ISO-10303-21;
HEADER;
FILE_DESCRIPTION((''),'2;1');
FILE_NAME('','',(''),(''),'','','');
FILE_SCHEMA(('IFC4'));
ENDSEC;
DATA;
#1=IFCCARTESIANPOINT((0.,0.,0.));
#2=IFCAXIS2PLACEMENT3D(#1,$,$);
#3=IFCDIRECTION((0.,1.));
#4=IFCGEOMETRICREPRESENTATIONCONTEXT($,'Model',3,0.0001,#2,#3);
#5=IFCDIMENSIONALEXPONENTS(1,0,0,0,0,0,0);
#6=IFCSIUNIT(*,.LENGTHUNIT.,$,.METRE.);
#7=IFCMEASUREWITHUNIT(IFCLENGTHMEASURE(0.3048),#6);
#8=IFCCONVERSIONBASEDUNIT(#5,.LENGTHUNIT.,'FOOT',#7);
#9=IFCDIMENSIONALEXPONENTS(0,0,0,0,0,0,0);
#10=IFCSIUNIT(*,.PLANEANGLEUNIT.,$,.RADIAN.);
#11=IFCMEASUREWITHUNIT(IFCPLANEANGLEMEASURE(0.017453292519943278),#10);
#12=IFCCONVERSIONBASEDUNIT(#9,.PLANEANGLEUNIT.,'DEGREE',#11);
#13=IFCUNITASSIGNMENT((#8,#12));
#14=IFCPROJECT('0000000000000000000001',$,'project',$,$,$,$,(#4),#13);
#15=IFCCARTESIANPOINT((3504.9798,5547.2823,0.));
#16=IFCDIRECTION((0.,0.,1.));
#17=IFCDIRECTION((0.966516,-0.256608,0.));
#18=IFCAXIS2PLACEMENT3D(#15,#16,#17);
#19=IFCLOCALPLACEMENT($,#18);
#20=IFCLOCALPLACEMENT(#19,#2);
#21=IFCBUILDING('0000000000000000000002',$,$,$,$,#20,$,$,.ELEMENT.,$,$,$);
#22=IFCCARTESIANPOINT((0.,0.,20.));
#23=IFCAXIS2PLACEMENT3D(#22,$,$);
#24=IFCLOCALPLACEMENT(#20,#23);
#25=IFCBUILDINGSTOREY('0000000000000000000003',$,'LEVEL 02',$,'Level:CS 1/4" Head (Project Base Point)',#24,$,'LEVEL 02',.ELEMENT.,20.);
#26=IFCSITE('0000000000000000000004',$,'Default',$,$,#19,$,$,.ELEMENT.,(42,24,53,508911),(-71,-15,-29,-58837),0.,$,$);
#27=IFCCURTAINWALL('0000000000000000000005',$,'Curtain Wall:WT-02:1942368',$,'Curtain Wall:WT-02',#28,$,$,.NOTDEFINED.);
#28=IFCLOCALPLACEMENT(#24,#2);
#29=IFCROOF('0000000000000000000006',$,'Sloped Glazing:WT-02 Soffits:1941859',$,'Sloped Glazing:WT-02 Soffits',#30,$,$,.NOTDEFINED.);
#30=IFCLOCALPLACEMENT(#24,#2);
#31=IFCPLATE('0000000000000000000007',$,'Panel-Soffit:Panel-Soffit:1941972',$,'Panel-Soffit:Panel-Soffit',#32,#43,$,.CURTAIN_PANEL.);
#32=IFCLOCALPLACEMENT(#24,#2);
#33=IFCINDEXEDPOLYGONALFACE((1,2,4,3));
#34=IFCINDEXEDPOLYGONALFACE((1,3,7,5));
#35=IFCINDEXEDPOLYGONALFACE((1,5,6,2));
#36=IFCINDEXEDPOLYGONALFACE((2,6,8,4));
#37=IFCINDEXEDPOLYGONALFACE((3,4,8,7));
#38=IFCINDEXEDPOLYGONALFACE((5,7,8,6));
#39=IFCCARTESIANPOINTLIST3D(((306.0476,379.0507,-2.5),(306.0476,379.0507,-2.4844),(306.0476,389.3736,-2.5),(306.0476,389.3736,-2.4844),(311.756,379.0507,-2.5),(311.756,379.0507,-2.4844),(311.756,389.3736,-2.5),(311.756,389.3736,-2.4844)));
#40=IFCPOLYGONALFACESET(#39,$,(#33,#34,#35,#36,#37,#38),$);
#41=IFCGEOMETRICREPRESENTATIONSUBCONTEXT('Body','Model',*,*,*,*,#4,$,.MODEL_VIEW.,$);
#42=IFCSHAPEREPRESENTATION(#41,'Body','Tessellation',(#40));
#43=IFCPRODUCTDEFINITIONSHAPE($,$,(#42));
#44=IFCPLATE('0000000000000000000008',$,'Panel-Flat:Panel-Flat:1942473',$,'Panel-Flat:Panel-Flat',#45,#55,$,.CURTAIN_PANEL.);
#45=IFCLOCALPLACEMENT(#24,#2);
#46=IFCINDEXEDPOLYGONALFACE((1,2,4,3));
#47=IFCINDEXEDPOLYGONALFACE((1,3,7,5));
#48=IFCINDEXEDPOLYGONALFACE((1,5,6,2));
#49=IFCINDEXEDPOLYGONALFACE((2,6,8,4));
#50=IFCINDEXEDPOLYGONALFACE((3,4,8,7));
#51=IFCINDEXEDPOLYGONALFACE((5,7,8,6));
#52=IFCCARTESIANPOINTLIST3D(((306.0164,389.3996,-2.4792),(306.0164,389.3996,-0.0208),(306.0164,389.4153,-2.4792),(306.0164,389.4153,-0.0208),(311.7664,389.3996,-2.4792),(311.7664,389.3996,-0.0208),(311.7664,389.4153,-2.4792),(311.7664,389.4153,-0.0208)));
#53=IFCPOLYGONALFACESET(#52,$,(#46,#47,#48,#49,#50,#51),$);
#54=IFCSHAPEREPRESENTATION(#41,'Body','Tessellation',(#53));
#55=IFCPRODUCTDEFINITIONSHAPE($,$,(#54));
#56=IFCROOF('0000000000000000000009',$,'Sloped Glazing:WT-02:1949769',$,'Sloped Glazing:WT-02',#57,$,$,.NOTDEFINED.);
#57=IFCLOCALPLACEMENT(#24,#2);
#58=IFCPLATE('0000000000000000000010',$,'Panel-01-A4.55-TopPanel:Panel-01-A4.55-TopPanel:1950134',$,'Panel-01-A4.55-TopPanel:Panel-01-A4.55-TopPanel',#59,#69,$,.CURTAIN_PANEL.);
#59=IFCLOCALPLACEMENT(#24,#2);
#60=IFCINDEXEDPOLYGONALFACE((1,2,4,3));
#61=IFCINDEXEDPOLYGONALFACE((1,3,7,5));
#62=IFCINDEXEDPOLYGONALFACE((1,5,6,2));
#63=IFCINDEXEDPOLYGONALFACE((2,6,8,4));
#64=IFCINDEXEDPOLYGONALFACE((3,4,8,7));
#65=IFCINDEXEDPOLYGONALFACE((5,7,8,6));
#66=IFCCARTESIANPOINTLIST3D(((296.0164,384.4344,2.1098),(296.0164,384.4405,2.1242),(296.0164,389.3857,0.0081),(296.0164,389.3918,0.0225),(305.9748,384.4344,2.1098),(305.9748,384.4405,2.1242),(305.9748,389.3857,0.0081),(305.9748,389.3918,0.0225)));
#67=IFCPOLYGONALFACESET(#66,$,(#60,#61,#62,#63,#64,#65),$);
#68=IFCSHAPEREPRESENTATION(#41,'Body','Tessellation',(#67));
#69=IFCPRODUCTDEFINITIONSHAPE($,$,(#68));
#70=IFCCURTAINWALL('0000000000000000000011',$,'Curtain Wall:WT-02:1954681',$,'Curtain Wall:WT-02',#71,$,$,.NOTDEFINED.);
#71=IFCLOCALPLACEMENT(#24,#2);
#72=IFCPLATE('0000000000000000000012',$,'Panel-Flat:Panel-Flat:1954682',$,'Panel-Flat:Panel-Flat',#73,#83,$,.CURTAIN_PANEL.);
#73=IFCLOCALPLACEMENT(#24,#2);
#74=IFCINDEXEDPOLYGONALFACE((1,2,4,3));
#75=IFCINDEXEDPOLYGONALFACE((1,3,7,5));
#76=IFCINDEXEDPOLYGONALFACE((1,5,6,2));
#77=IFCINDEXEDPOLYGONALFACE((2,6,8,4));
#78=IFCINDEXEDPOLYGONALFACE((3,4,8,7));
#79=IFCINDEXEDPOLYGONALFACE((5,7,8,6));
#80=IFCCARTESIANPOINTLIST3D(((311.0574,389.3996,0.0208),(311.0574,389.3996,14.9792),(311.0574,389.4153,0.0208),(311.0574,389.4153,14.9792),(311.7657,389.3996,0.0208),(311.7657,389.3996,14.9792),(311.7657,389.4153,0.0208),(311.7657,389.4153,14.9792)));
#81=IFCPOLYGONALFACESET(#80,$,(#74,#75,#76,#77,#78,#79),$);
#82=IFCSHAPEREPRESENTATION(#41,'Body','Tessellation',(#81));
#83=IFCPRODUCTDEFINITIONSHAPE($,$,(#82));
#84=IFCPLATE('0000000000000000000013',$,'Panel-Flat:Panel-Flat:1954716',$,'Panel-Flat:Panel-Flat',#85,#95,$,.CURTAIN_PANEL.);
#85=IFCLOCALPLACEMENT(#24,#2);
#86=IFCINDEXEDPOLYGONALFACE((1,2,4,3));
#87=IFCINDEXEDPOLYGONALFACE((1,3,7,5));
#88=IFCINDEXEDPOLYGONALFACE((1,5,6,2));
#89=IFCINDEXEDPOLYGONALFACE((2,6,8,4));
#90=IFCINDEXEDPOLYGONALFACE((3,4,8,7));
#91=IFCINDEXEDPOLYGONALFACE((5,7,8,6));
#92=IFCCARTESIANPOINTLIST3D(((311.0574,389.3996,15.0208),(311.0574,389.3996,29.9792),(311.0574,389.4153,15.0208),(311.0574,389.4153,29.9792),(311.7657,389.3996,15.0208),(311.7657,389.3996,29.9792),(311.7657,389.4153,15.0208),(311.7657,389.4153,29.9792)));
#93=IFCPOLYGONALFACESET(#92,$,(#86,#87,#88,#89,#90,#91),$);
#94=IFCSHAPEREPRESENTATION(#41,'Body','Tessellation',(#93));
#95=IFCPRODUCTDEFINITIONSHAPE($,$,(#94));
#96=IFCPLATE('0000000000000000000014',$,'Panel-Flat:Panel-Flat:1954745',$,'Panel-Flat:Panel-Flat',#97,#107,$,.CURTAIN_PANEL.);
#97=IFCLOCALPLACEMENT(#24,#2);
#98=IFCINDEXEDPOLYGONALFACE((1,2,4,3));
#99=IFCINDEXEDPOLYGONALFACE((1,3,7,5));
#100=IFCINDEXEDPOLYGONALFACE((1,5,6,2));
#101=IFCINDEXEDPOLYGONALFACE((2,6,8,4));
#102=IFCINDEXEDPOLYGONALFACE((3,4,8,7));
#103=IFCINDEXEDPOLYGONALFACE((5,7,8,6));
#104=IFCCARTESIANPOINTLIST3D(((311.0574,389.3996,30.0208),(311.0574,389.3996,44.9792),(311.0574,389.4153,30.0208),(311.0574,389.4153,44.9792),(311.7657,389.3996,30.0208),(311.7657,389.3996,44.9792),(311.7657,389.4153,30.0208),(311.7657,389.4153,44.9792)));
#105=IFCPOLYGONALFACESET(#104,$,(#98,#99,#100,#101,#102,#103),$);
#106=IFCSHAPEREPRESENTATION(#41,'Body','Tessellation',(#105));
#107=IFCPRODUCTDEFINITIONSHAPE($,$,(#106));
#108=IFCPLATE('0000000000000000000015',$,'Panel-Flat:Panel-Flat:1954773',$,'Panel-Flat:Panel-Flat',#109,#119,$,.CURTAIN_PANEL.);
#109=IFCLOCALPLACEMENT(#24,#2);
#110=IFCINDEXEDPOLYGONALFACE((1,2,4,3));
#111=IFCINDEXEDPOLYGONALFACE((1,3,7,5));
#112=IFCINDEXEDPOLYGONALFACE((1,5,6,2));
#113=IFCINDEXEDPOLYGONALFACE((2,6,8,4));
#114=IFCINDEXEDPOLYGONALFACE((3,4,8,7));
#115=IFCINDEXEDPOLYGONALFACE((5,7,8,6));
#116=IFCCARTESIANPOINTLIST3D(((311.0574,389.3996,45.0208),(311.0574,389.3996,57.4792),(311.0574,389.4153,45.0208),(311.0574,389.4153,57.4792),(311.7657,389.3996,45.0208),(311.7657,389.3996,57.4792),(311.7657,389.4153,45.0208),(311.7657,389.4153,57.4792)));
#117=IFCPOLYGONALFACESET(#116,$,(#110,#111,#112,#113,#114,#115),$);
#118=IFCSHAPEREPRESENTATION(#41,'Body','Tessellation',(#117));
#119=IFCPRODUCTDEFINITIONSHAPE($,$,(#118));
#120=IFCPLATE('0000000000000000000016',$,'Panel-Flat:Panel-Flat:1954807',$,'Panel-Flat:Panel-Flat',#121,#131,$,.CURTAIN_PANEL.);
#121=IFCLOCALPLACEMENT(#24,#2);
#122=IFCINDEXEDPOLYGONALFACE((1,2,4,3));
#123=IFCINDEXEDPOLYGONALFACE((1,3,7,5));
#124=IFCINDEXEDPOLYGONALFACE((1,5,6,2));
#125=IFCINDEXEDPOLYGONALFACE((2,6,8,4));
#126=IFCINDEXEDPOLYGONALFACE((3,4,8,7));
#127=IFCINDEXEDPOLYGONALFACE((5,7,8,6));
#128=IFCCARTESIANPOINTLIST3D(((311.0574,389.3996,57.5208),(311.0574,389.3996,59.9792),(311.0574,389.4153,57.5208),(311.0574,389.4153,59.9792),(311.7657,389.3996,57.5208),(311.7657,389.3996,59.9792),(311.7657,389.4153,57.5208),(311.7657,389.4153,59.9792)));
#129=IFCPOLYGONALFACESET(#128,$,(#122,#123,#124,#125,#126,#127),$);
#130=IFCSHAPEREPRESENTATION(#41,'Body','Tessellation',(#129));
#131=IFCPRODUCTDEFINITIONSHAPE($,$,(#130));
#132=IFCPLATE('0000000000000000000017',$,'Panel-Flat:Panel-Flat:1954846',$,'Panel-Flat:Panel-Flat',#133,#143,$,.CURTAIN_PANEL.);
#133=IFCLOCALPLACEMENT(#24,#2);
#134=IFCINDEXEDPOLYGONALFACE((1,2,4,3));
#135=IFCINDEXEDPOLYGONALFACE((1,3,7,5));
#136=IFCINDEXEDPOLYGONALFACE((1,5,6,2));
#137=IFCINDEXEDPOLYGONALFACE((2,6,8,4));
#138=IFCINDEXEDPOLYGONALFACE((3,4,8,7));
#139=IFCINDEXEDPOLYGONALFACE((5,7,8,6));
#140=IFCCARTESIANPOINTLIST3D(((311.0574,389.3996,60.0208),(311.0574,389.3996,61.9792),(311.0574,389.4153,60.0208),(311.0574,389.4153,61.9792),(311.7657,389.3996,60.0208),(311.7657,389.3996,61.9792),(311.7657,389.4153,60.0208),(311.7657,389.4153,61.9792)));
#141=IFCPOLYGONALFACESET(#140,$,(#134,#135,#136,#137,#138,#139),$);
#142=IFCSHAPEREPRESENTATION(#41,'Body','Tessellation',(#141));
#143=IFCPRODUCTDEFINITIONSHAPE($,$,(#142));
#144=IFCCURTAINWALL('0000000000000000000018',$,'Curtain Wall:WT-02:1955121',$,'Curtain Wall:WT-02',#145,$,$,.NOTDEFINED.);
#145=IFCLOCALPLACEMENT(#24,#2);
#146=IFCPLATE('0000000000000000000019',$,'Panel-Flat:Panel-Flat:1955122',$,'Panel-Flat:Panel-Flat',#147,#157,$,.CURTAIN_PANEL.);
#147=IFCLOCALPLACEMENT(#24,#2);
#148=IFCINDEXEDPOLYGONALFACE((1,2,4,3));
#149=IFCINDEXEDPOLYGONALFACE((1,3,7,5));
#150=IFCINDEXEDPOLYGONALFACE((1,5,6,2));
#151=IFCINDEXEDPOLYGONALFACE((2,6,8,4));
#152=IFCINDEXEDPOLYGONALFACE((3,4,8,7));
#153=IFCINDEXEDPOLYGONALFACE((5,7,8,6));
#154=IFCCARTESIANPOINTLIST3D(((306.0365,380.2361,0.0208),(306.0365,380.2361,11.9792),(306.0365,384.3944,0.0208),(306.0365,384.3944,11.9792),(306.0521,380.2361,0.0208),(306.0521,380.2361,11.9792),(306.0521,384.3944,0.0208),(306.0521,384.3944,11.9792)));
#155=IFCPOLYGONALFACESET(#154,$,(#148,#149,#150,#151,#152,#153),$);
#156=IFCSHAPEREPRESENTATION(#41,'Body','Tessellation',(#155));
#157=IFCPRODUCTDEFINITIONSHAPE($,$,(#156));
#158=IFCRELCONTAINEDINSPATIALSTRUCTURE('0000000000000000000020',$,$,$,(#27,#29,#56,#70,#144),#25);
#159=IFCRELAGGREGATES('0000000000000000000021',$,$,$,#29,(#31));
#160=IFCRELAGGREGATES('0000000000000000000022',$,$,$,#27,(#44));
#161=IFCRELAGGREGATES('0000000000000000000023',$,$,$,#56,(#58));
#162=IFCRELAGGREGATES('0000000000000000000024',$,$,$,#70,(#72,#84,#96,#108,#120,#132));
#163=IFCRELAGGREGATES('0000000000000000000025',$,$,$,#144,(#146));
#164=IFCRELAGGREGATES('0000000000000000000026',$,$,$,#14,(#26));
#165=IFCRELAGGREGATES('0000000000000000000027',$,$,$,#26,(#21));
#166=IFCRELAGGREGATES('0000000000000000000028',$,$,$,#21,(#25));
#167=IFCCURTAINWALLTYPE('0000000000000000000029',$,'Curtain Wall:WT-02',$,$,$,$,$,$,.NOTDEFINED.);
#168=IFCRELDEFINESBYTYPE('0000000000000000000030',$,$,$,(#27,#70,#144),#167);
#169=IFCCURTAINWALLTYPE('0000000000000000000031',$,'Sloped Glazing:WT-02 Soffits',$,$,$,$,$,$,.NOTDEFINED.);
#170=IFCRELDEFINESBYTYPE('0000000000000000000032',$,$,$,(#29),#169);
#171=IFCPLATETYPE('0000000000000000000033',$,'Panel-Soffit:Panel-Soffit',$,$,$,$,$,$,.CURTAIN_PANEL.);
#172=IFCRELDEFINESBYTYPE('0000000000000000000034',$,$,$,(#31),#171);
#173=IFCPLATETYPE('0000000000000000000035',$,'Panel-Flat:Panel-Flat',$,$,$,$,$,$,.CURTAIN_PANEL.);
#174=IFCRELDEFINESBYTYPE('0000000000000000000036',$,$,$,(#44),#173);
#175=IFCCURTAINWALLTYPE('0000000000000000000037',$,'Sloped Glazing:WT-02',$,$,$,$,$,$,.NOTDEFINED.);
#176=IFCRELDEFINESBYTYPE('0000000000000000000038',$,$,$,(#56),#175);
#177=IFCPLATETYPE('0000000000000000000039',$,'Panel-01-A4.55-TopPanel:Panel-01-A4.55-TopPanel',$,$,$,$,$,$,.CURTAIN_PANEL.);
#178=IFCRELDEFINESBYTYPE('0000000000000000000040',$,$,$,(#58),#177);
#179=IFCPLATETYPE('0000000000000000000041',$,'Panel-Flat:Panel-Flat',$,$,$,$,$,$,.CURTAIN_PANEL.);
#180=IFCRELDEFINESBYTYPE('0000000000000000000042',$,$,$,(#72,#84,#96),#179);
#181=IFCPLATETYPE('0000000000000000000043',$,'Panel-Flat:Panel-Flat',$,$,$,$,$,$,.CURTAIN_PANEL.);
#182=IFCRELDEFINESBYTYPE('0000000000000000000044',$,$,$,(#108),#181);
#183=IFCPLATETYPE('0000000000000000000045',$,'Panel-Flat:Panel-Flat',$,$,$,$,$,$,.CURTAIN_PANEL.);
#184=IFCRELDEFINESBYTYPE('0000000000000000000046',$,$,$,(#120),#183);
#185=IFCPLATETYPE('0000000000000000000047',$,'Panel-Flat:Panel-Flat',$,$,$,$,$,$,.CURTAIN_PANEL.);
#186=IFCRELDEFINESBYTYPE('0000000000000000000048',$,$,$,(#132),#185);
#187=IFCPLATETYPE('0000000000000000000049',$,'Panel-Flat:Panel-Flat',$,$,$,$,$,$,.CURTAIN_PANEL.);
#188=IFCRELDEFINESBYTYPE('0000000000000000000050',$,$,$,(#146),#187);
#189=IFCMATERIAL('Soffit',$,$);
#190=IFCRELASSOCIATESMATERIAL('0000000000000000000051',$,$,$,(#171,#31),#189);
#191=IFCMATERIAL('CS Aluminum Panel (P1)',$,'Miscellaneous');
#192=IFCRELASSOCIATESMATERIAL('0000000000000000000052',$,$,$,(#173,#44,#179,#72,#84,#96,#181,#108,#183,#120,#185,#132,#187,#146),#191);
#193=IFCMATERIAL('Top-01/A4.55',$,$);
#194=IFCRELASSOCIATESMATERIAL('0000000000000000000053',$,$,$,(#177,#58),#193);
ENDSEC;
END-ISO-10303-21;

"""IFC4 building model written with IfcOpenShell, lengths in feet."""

from ifc_helpers import new_model, entity, si_unit, converted_unit, direction, frame, origin, place, context, subcontext, project, spatial, indexed_curve, outline, extrude, source, transform, mapped, material, type_object, type_shapes, element, aggregate, save


model = new_model("IFC4")

# Units and contexts
model_context = context("Model", 3, precision=0.0001, world=origin(), true_north=direction((0.0, 1.0)))
body_context = subcontext(model_context, "Body", "Model", "MODEL_VIEW")
ifc_project = project(units=[converted_unit("LENGTHUNIT", "FOOT", entity("IfcLengthMeasure", 0.3048), si_unit("LENGTHUNIT", "METRE"), dimensions=[1, 0, 0, 0, 0, 0, 0]), converted_unit("PLANEANGLEUNIT", "DEGREE", entity("IfcPlaneAngleMeasure", 0.017453292519943278), si_unit("PLANEANGLEUNIT", "RADIAN"), dimensions=[0, 0, 0, 0, 0, 0, 0])], contexts=[model_context])

# Site, building, storey
site_placement = place(None, frame((3504.9798, 5547.2823, 0.0), z_axis=(0.0, 0.0, 1.0), x_axis=(0.966516, -0.256608, 0.0)))
site = spatial("IfcSite", under=ifc_project, at=site_placement, Name="Default", CompositionType="ELEMENT", RefLatitude=(42, 24, 53, 508911), RefLongitude=(-71, -15, -29, -58837), RefElevation=0.0)
building_placement = place(site_placement, origin())
building = spatial("IfcBuilding", under=site, at=building_placement, CompositionType="ELEMENT")
storey_placement = place(building_placement, frame((0.0, 0.0, 20.0)))
storey = spatial("IfcBuildingStorey", under=building, at=storey_placement, Name="LEVEL 02", ObjectType="Level:CS 1/4\" Head (Project Base Point)", LongName="LEVEL 02", CompositionType="ELEMENT", Elevation=20.0)

# Shared definitions
curtain_wall_type_1 = type_object("IfcCurtainWallType", Name="Curtain Wall:WT-02", PredefinedType="NOTDEFINED")
ifc_material_1 = material(Name="CS Aluminum Panel (P1)", Category="Miscellaneous")

# Curtain wall
curtain_wall_1_placement = place(storey_placement, frame((0.0, 0.0, -20.0)))
curtain_wall_1 = element("IfcCurtainWall", 1, at=curtain_wall_1_placement, inside=storey, type_object=curtain_wall_type_1, Name="Curtain Wall:WT-02:1942368", ObjectType="Curtain Wall:WT-02", PredefinedType="NOTDEFINED")

# Roof, plate
curtain_wall_type_2 = type_object("IfcCurtainWallType", Name="Sloped Glazing:WT-02", PredefinedType="NOTDEFINED")
curtain_wall_type_3 = type_object("IfcCurtainWallType", Name="Sloped Glazing:WT-02 Soffits", PredefinedType="NOTDEFINED")
roof_1_placement = place(storey_placement, frame((0.0, 0.0, -20.0)))
roof_1 = element("IfcRoof", 2, at=roof_1_placement, inside=storey, type_object=curtain_wall_type_3, Name="Sloped Glazing:WT-02 Soffits:1941859", ObjectType="Sloped Glazing:WT-02 Soffits", PredefinedType="NOTDEFINED")
ifc_material_2 = material(Name="Soffit")
plate_type_1 = type_object("IfcPlateType", Name="Panel-Soffit:Panel-Soffit", PredefinedType="CURTAIN_PANEL", material=ifc_material_2)
shared_shape_1 = source(origin(), body_context, "Body", "SweptSolid", [
    extrude(outline(indexed_curve([(-0.0078, -2.8542), (0.0078, -2.8542), (0.0078, 2.8542), (-0.0078, 2.8542), (-0.0078, -2.8542)], self_intersect=False)), frame((0.0, -0.0078, 0.0208), z_axis=(0.0, 0.0, 1.0), x_axis=(0.0, -1.0, 0.0)), (0.0, 0.0, 1.0), 10.3229),
])
type_shapes(plate_type_1, [shared_shape_1])
plate_1_placement = place(roof_1_placement, frame((308.9018, 379.0298, 17.5), z_axis=(0.0, 1.0, 0.0), x_axis=(1.0, 0.0, 0.0)))
plate_1 = element("IfcPlate", 3, at=plate_1_placement, type_object=plate_type_1, material=ifc_material_2, Name="Panel-Soffit:Panel-Soffit:1941972", ObjectType="Panel-Soffit:Panel-Soffit", PredefinedType="CURTAIN_PANEL", context=body_context, shape_type="MappedRepresentation", body=[
    mapped(shared_shape_1, transform((0.0, 0.0, 0.0), scale=1.0)),
])
aggregate(roof_1, [plate_1])

# Plate
plate_type_2 = type_object("IfcPlateType", Name="Panel-Flat:Panel-Flat", PredefinedType="CURTAIN_PANEL", material=ifc_material_1)
shared_shape_2 = source(origin(), body_context, "Body", "SweptSolid", [
    extrude(outline(indexed_curve([(-0.0078, -2.875), (0.0078, -2.875), (0.0078, 2.875), (-0.0078, 2.875), (-0.0078, -2.875)], self_intersect=False)), frame((0.0, -0.0078, 0.0208), z_axis=(0.0, 0.0, 1.0), x_axis=(0.0, -1.0, 0.0)), (0.0, 0.0, 1.0), 2.4583),
])
type_shapes(plate_type_2, [shared_shape_2])
plate_2_placement = place(curtain_wall_1_placement, frame((308.8914, 389.4153, 17.5)))
plate_2 = element("IfcPlate", 4, at=plate_2_placement, type_object=plate_type_2, material=ifc_material_1, Name="Panel-Flat:Panel-Flat:1942473", ObjectType="Panel-Flat:Panel-Flat", PredefinedType="CURTAIN_PANEL", context=body_context, shape_type="MappedRepresentation", body=[
    mapped(shared_shape_2, transform((0.0, 0.0, 0.0), scale=1.0)),
])
aggregate(curtain_wall_1, [plate_2])

# Roof, plate
roof_2_placement = place(storey_placement, frame((0.0, 0.0, -20.0)))
roof_2 = element("IfcRoof", 5, at=roof_2_placement, inside=storey, type_object=curtain_wall_type_2, Name="Sloped Glazing:WT-02:1949769", ObjectType="Sloped Glazing:WT-02", PredefinedType="NOTDEFINED")
ifc_material_3 = material(Name="Top-01/A4.55")
plate_type_3 = type_object("IfcPlateType", Name="Panel-01-A4.55-TopPanel:Panel-01-A4.55-TopPanel", PredefinedType="CURTAIN_PANEL", material=ifc_material_3)
shared_shape_3 = source(origin(), body_context, "Body", "SweptSolid", [
    extrude(outline(indexed_curve([(-0.0078, -4.9792), (0.0078, -4.9792), (0.0078, 4.9792), (-0.0078, 4.9792), (-0.0078, -4.9792)], self_intersect=False)), frame((0.0, -0.0078, 0.0208), z_axis=(0.0, 0.0, 1.0), x_axis=(0.0, -1.0, 0.0)), (0.0, 0.0, 1.0), 5.3788),
])
type_shapes(plate_type_3, [shared_shape_3])
plate_3_placement = place(roof_2_placement, frame((300.9956, 389.4048, 20.0), z_axis=(0.0, -0.920505, 0.390731), x_axis=(-1.0, 0.0, 0.0)))
plate_3 = element("IfcPlate", 6, at=plate_3_placement, type_object=plate_type_3, material=ifc_material_3, Name="Panel-01-A4.55-TopPanel:Panel-01-A4.55-TopPanel:1950134", ObjectType="Panel-01-A4.55-TopPanel:Panel-01-A4.55-TopPanel", PredefinedType="CURTAIN_PANEL", context=body_context, shape_type="MappedRepresentation", body=[
    mapped(shared_shape_3, transform((0.0, 0.0, 0.0), scale=1.0)),
])
aggregate(roof_2, [plate_3])

# Curtain wall, plates
curtain_wall_2_placement = place(storey_placement, frame((0.0, 0.0, -20.0)))
curtain_wall_2 = element("IfcCurtainWall", 7, at=curtain_wall_2_placement, inside=storey, type_object=curtain_wall_type_1, Name="Curtain Wall:WT-02:1954681", ObjectType="Curtain Wall:WT-02", PredefinedType="NOTDEFINED")
plate_type_4 = type_object("IfcPlateType", Name="Panel-Flat:Panel-Flat", PredefinedType="CURTAIN_PANEL", material=ifc_material_1)
shared_shape_4 = source(origin(), body_context, "Body", "SweptSolid", [
    extrude(outline(indexed_curve([(-0.0078, -0.3542), (0.0078, -0.3542), (0.0078, 0.3542), (-0.0078, 0.3542), (-0.0078, -0.3542)], self_intersect=False)), frame((0.0, -0.0078, 0.0208), z_axis=(0.0, 0.0, 1.0), x_axis=(0.0, -1.0, 0.0)), (0.0, 0.0, 1.0), 14.9583),
])
type_shapes(plate_type_4, [shared_shape_4])
plate_4_placement = place(curtain_wall_2_placement, frame((311.4115, 389.4153, 20.0)))
plate_4 = element("IfcPlate", 8, at=plate_4_placement, type_object=plate_type_4, material=ifc_material_1, Name="Panel-Flat:Panel-Flat:1954682", ObjectType="Panel-Flat:Panel-Flat", PredefinedType="CURTAIN_PANEL", context=body_context, shape_type="MappedRepresentation", body=[
    mapped(shared_shape_4, transform((0.0, 0.0, 0.0), scale=1.0)),
])
plate_5_placement = place(curtain_wall_2_placement, frame((311.4115, 389.4153, 35.0)))
plate_5 = element("IfcPlate", 9, at=plate_5_placement, type_object=plate_type_4, material=ifc_material_1, Name="Panel-Flat:Panel-Flat:1954716", ObjectType="Panel-Flat:Panel-Flat", PredefinedType="CURTAIN_PANEL", context=body_context, shape_type="MappedRepresentation", body=[
    mapped(shared_shape_4, transform((0.0, 0.0, 0.0), scale=1.0)),
])
plate_6_placement = place(curtain_wall_2_placement, frame((311.4115, 389.4153, 50.0)))
plate_6 = element("IfcPlate", 10, at=plate_6_placement, type_object=plate_type_4, material=ifc_material_1, Name="Panel-Flat:Panel-Flat:1954745", ObjectType="Panel-Flat:Panel-Flat", PredefinedType="CURTAIN_PANEL", context=body_context, shape_type="MappedRepresentation", body=[
    mapped(shared_shape_4, transform((0.0, 0.0, 0.0), scale=1.0)),
])
plate_type_5 = type_object("IfcPlateType", Name="Panel-Flat:Panel-Flat", PredefinedType="CURTAIN_PANEL", material=ifc_material_1)
shared_shape_5 = source(origin(), body_context, "Body", "SweptSolid", [
    extrude(outline(indexed_curve([(-0.0078, -0.3542), (0.0078, -0.3542), (0.0078, 0.3542), (-0.0078, 0.3542), (-0.0078, -0.3542)], self_intersect=False)), frame((0.0, -0.0078, 0.0208), z_axis=(0.0, 0.0, 1.0), x_axis=(0.0, -1.0, 0.0)), (0.0, 0.0, 1.0), 12.4583),
])
type_shapes(plate_type_5, [shared_shape_5])
plate_7_placement = place(curtain_wall_2_placement, frame((311.4115, 389.4153, 65.0)))
plate_7 = element("IfcPlate", 11, at=plate_7_placement, type_object=plate_type_5, material=ifc_material_1, Name="Panel-Flat:Panel-Flat:1954773", ObjectType="Panel-Flat:Panel-Flat", PredefinedType="CURTAIN_PANEL", context=body_context, shape_type="MappedRepresentation", body=[
    mapped(shared_shape_5, transform((0.0, 0.0, 0.0), scale=1.0)),
])
plate_type_6 = type_object("IfcPlateType", Name="Panel-Flat:Panel-Flat", PredefinedType="CURTAIN_PANEL", material=ifc_material_1)
shared_shape_6 = source(origin(), body_context, "Body", "SweptSolid", [
    extrude(outline(indexed_curve([(-0.0078, -0.3542), (0.0078, -0.3542), (0.0078, 0.3542), (-0.0078, 0.3542), (-0.0078, -0.3542)], self_intersect=False)), frame((0.0, -0.0078, 0.0208), z_axis=(0.0, 0.0, 1.0), x_axis=(0.0, -1.0, 0.0)), (0.0, 0.0, 1.0), 2.4583),
])
type_shapes(plate_type_6, [shared_shape_6])
plate_8_placement = place(curtain_wall_2_placement, frame((311.4115, 389.4153, 77.5)))
plate_8 = element("IfcPlate", 12, at=plate_8_placement, type_object=plate_type_6, material=ifc_material_1, Name="Panel-Flat:Panel-Flat:1954807", ObjectType="Panel-Flat:Panel-Flat", PredefinedType="CURTAIN_PANEL", context=body_context, shape_type="MappedRepresentation", body=[
    mapped(shared_shape_6, transform((0.0, 0.0, 0.0), scale=1.0)),
])
plate_type_7 = type_object("IfcPlateType", Name="Panel-Flat:Panel-Flat", PredefinedType="CURTAIN_PANEL", material=ifc_material_1)
shared_shape_7 = source(origin(), body_context, "Body", "SweptSolid", [
    extrude(outline(indexed_curve([(-0.0078, -0.3542), (0.0078, -0.3542), (0.0078, 0.3542), (-0.0078, 0.3542), (-0.0078, -0.3542)], self_intersect=False)), frame((0.0, -0.0078, 0.0208), z_axis=(0.0, 0.0, 1.0), x_axis=(0.0, -1.0, 0.0)), (0.0, 0.0, 1.0), 1.9583),
])
type_shapes(plate_type_7, [shared_shape_7])
plate_9_placement = place(curtain_wall_2_placement, frame((311.4115, 389.4153, 80.0)))
plate_9 = element("IfcPlate", 13, at=plate_9_placement, type_object=plate_type_7, material=ifc_material_1, Name="Panel-Flat:Panel-Flat:1954846", ObjectType="Panel-Flat:Panel-Flat", PredefinedType="CURTAIN_PANEL", context=body_context, shape_type="MappedRepresentation", body=[
    mapped(shared_shape_7, transform((0.0, 0.0, 0.0), scale=1.0)),
])
aggregate(curtain_wall_2, [plate_4, plate_5, plate_6, plate_7, plate_8, plate_9])

# Curtain wall, plate
curtain_wall_3_placement = place(storey_placement, frame((0.0, 0.0, -20.0)))
curtain_wall_3 = element("IfcCurtainWall", 14, at=curtain_wall_3_placement, inside=storey, type_object=curtain_wall_type_1, Name="Curtain Wall:WT-02:1955121", ObjectType="Curtain Wall:WT-02", PredefinedType="NOTDEFINED")
plate_type_8 = type_object("IfcPlateType", Name="Panel-Flat:Panel-Flat", PredefinedType="CURTAIN_PANEL", material=ifc_material_1)
shared_shape_8 = source(origin(), body_context, "Body", "SweptSolid", [
    extrude(outline(indexed_curve([(-0.0078, -2.0791), (0.0078, -2.0791), (0.0078, 2.0791), (-0.0078, 2.0791), (-0.0078, -2.0791)], self_intersect=False)), frame((0.0, -0.0078, 0.0208), z_axis=(0.0, 0.0, 1.0), x_axis=(0.0, -1.0, 0.0)), (0.0, 0.0, 1.0), 11.9583),
])
type_shapes(plate_type_8, [shared_shape_8])
plate_10_placement = place(curtain_wall_3_placement, frame((306.0365, 382.3153, 20.0), z_axis=(0.0, 0.0, 1.0), x_axis=(0.0, 1.0, 0.0)))
plate_10 = element("IfcPlate", 15, at=plate_10_placement, type_object=plate_type_8, material=ifc_material_1, Name="Panel-Flat:Panel-Flat:1955122", ObjectType="Panel-Flat:Panel-Flat", PredefinedType="CURTAIN_PANEL", context=body_context, shape_type="MappedRepresentation", body=[
    mapped(shared_shape_8, transform((0.0, 0.0, 0.0), scale=1.0)),
])
aggregate(curtain_wall_3, [plate_10])

save(model, "model.ifc")
